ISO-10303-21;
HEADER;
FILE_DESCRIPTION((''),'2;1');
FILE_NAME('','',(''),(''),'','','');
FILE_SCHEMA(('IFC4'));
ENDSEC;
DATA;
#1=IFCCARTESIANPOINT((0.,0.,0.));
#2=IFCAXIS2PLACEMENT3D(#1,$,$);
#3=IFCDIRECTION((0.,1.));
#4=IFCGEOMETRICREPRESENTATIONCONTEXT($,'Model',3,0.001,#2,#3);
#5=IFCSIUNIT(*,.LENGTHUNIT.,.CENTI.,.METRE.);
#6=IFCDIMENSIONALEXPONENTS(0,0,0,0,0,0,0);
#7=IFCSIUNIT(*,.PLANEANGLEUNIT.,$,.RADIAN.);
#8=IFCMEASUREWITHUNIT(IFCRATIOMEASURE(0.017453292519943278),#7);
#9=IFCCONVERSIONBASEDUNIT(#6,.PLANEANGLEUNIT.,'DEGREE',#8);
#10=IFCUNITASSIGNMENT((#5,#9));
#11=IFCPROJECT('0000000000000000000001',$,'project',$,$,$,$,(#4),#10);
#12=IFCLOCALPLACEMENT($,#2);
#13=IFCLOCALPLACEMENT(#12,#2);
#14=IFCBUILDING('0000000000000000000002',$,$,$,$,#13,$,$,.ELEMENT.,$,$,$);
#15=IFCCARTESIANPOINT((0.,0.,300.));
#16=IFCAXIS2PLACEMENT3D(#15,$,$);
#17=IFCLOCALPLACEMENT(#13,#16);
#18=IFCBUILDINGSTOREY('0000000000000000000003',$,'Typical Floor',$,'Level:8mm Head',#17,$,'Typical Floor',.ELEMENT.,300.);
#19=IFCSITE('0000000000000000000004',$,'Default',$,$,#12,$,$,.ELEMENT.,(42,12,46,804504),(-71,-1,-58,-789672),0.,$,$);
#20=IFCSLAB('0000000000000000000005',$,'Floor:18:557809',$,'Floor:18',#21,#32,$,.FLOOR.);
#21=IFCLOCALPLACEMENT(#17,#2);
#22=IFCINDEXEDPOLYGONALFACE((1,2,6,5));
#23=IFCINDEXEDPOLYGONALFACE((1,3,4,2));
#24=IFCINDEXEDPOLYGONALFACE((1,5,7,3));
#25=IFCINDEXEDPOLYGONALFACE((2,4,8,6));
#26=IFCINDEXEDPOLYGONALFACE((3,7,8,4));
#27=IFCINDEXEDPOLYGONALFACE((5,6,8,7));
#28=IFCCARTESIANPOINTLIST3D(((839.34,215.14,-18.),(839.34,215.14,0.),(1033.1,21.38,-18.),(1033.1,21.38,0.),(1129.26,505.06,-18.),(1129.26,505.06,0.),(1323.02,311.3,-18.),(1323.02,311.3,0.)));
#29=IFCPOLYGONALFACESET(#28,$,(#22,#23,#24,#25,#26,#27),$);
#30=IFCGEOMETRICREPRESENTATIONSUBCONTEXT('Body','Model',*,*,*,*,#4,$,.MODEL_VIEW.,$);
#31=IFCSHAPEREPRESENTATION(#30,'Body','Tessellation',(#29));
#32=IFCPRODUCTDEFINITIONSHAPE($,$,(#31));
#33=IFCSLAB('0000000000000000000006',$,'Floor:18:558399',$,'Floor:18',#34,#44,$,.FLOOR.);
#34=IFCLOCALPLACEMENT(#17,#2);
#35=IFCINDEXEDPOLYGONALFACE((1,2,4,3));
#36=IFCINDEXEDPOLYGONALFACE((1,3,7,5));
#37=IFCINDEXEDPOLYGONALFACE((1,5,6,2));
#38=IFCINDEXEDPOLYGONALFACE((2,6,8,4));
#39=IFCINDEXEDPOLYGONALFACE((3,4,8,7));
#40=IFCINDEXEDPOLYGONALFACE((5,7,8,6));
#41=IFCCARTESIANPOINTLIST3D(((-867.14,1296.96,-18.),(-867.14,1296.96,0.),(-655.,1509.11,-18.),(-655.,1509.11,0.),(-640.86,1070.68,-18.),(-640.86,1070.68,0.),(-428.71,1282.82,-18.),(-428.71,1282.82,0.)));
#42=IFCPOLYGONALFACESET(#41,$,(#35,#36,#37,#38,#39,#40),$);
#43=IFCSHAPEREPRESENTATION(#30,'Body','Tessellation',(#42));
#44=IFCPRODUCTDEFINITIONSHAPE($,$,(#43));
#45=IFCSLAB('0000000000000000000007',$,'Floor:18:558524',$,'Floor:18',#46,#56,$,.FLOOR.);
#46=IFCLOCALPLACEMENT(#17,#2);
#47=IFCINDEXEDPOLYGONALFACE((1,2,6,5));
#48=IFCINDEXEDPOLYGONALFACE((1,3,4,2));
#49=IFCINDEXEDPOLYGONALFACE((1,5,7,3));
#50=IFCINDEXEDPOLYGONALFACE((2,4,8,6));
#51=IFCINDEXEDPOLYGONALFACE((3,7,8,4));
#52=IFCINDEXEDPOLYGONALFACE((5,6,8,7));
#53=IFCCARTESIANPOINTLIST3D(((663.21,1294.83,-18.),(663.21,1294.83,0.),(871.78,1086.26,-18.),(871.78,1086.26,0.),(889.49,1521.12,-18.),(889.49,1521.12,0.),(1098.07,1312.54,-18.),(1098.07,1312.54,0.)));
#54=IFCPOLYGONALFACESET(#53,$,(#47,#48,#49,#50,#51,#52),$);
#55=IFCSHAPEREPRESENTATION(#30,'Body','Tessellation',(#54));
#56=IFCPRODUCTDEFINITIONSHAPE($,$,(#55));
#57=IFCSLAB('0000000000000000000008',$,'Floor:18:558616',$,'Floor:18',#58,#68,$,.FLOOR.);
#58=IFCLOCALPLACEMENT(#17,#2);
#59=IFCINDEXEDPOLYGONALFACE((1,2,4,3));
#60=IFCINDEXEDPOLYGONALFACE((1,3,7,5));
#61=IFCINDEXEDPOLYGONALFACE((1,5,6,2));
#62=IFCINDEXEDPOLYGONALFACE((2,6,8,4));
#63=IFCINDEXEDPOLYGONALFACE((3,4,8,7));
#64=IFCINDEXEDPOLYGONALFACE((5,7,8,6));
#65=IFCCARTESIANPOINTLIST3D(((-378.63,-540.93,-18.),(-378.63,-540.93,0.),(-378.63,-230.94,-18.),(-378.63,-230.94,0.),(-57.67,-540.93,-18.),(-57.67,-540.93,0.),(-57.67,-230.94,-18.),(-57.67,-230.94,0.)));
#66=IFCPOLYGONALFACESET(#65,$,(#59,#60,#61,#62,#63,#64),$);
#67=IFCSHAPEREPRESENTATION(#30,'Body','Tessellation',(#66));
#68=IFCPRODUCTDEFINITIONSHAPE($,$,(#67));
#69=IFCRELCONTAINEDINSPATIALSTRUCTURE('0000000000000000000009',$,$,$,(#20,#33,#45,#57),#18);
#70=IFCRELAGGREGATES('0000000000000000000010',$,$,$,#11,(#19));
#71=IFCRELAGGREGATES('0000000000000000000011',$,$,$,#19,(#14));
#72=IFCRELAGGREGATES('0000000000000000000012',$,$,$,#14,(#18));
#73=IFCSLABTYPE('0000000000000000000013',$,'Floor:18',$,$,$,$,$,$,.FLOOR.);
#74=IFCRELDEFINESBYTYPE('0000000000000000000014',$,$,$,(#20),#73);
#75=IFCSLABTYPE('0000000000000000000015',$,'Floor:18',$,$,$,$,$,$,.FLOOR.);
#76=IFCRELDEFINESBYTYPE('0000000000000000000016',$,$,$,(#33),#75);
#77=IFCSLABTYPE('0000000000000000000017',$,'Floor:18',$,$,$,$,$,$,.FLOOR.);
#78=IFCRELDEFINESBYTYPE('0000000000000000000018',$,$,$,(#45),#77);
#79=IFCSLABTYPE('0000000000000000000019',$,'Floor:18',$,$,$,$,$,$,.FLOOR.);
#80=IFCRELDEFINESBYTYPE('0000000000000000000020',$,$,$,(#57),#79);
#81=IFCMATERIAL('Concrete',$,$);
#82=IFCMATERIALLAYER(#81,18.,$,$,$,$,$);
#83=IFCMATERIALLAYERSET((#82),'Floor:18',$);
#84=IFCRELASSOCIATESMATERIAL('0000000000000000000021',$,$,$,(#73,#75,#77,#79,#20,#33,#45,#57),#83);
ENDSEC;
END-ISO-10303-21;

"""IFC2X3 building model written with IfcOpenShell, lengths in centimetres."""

from ifc_helpers import new_model, entity, si_unit, converted_unit, direction, frame, frame_2d, origin, origin_2d_with_axis, place, context, subcontext, project, spatial, rectangle, extrude, material, layer, layer_set, layer_usage, type_object, element, save


model = new_model("IFC2X3")

# Units and contexts
model_context = context("Model", 3, precision=0.001, world=origin(), true_north=direction((0.0, 1.0)))
body_context = subcontext(model_context, "Body", "Model", "MODEL_VIEW")
ifc_project = project(units=[si_unit("LENGTHUNIT", "METRE", prefix="CENTI"), converted_unit("PLANEANGLEUNIT", "DEGREE", entity("IfcRatioMeasure", 0.017453292519943278), si_unit("PLANEANGLEUNIT", "RADIAN"), dimensions=[0, 0, 0, 0, 0, 0, 0])], contexts=[model_context])

# Site, building, storey
site_placement = place(None, origin())
site = spatial("IfcSite", under=ifc_project, at=site_placement, Name="Default", CompositionType="ELEMENT", RefLatitude=(42, 12, 46, 804504), RefLongitude=(-71, -1, -58, -789672), RefElevation=0.0)
building_placement = place(site_placement, origin())
building = spatial("IfcBuilding", under=site, at=building_placement, CompositionType="ELEMENT")
storey_placement = place(building_placement, frame((0.0, 0.0, 300.0)))
storey = spatial("IfcBuildingStorey", under=building, at=storey_placement, Name="Typical Floor", ObjectType="Level:8mm Head", LongName="Typical Floor", CompositionType="ELEMENT", Elevation=300.0)

# Slabs
ifc_material = material(Name="Concrete")
ifc_layer = layer(ifc_material, 18.0)
ifc_layer_set = layer_set([ifc_layer], Name="Floor:18")
ifc_layer_usage_1 = layer_usage(ifc_layer_set, "AXIS3", "POSITIVE", 0.0)
slab_type_1 = type_object("IfcSlabType", Name="Floor:18", PredefinedType="FLOOR", material=ifc_layer_set)
slab_1_placement = place(storey_placement, origin())
element("IfcSlab", 1, at=slab_1_placement, inside=storey, type_object=slab_type_1, material=ifc_layer_usage_1, Name="Floor:18:557809", ObjectType="Floor:18", PredefinedType="FLOOR", context=body_context, shape_type="SweptSolid", body=[
    extrude(rectangle(XDim=410.0, YDim=274.02, at=frame_2d((0.0, 0.0), x_axis=(1.0, 0.0))), frame((1081.18, 263.22, 0.0), z_axis=(0.0, 0.0, -1.0), x_axis=(-0.707107, -0.707107, 0.0)), (0.0, 0.0, 1.0), 18.0),
])
ifc_layer_usage_2 = layer_usage(ifc_layer_set, "AXIS3", "POSITIVE", 0.0)
slab_type_2 = type_object("IfcSlabType", Name="Floor:18", PredefinedType="FLOOR", material=ifc_layer_set)
slab_2_placement = place(storey_placement, origin())
element("IfcSlab", 2, at=slab_2_placement, inside=storey, type_object=slab_type_2, material=ifc_layer_usage_2, Name="Floor:18:558399", ObjectType="Floor:18", PredefinedType="FLOOR", context=body_context, shape_type="SweptSolid", body=[
    extrude(rectangle(XDim=300.02, YDim=320.01, at=origin_2d_with_axis()), frame((-647.93, 1289.89, 0.0), z_axis=(0.0, 0.0, -1.0), x_axis=(-0.707107, -0.707107, 0.0)), (0.0, 0.0, 1.0), 18.0),
])
ifc_layer_usage_3 = layer_usage(ifc_layer_set, "AXIS3", "POSITIVE", 0.0)
slab_type_3 = type_object("IfcSlabType", Name="Floor:18", PredefinedType="FLOOR", material=ifc_layer_set)
slab_3_placement = place(storey_placement, origin())
element("IfcSlab", 3, at=slab_3_placement, inside=storey, type_object=slab_type_3, material=ifc_layer_usage_3, Name="Floor:18:558524", ObjectType="Floor:18", PredefinedType="FLOOR", context=body_context, shape_type="SweptSolid", body=[
    extrude(rectangle(XDim=320.01, YDim=294.97, at=frame_2d((0.0, 0.0), x_axis=(1.0, 0.0))), frame((880.64, 1303.69, 0.0), z_axis=(0.0, 0.0, -1.0), x_axis=(-0.707107, -0.707107, 0.0)), (0.0, 0.0, 1.0), 18.0),
])
ifc_layer_usage_4 = layer_usage(ifc_layer_set, "AXIS3", "POSITIVE", 0.0)
slab_type_4 = type_object("IfcSlabType", Name="Floor:18", PredefinedType="FLOOR", material=ifc_layer_set)
slab_4_placement = place(storey_placement, origin())
element("IfcSlab", 4, at=slab_4_placement, inside=storey, type_object=slab_type_4, material=ifc_layer_usage_4, Name="Floor:18:558616", ObjectType="Floor:18", PredefinedType="FLOOR", context=body_context, shape_type="SweptSolid", body=[
    extrude(rectangle(XDim=309.99, YDim=320.96, at=frame_2d((0.0, 0.0), x_axis=(1.0, 0.0))), frame((-218.15, -385.94, 0.0), z_axis=(0.0, 0.0, -1.0), x_axis=(0.0, 1.0, 0.0)), (0.0, 0.0, 1.0), 18.0),
])

save(model, "model.ifc")
